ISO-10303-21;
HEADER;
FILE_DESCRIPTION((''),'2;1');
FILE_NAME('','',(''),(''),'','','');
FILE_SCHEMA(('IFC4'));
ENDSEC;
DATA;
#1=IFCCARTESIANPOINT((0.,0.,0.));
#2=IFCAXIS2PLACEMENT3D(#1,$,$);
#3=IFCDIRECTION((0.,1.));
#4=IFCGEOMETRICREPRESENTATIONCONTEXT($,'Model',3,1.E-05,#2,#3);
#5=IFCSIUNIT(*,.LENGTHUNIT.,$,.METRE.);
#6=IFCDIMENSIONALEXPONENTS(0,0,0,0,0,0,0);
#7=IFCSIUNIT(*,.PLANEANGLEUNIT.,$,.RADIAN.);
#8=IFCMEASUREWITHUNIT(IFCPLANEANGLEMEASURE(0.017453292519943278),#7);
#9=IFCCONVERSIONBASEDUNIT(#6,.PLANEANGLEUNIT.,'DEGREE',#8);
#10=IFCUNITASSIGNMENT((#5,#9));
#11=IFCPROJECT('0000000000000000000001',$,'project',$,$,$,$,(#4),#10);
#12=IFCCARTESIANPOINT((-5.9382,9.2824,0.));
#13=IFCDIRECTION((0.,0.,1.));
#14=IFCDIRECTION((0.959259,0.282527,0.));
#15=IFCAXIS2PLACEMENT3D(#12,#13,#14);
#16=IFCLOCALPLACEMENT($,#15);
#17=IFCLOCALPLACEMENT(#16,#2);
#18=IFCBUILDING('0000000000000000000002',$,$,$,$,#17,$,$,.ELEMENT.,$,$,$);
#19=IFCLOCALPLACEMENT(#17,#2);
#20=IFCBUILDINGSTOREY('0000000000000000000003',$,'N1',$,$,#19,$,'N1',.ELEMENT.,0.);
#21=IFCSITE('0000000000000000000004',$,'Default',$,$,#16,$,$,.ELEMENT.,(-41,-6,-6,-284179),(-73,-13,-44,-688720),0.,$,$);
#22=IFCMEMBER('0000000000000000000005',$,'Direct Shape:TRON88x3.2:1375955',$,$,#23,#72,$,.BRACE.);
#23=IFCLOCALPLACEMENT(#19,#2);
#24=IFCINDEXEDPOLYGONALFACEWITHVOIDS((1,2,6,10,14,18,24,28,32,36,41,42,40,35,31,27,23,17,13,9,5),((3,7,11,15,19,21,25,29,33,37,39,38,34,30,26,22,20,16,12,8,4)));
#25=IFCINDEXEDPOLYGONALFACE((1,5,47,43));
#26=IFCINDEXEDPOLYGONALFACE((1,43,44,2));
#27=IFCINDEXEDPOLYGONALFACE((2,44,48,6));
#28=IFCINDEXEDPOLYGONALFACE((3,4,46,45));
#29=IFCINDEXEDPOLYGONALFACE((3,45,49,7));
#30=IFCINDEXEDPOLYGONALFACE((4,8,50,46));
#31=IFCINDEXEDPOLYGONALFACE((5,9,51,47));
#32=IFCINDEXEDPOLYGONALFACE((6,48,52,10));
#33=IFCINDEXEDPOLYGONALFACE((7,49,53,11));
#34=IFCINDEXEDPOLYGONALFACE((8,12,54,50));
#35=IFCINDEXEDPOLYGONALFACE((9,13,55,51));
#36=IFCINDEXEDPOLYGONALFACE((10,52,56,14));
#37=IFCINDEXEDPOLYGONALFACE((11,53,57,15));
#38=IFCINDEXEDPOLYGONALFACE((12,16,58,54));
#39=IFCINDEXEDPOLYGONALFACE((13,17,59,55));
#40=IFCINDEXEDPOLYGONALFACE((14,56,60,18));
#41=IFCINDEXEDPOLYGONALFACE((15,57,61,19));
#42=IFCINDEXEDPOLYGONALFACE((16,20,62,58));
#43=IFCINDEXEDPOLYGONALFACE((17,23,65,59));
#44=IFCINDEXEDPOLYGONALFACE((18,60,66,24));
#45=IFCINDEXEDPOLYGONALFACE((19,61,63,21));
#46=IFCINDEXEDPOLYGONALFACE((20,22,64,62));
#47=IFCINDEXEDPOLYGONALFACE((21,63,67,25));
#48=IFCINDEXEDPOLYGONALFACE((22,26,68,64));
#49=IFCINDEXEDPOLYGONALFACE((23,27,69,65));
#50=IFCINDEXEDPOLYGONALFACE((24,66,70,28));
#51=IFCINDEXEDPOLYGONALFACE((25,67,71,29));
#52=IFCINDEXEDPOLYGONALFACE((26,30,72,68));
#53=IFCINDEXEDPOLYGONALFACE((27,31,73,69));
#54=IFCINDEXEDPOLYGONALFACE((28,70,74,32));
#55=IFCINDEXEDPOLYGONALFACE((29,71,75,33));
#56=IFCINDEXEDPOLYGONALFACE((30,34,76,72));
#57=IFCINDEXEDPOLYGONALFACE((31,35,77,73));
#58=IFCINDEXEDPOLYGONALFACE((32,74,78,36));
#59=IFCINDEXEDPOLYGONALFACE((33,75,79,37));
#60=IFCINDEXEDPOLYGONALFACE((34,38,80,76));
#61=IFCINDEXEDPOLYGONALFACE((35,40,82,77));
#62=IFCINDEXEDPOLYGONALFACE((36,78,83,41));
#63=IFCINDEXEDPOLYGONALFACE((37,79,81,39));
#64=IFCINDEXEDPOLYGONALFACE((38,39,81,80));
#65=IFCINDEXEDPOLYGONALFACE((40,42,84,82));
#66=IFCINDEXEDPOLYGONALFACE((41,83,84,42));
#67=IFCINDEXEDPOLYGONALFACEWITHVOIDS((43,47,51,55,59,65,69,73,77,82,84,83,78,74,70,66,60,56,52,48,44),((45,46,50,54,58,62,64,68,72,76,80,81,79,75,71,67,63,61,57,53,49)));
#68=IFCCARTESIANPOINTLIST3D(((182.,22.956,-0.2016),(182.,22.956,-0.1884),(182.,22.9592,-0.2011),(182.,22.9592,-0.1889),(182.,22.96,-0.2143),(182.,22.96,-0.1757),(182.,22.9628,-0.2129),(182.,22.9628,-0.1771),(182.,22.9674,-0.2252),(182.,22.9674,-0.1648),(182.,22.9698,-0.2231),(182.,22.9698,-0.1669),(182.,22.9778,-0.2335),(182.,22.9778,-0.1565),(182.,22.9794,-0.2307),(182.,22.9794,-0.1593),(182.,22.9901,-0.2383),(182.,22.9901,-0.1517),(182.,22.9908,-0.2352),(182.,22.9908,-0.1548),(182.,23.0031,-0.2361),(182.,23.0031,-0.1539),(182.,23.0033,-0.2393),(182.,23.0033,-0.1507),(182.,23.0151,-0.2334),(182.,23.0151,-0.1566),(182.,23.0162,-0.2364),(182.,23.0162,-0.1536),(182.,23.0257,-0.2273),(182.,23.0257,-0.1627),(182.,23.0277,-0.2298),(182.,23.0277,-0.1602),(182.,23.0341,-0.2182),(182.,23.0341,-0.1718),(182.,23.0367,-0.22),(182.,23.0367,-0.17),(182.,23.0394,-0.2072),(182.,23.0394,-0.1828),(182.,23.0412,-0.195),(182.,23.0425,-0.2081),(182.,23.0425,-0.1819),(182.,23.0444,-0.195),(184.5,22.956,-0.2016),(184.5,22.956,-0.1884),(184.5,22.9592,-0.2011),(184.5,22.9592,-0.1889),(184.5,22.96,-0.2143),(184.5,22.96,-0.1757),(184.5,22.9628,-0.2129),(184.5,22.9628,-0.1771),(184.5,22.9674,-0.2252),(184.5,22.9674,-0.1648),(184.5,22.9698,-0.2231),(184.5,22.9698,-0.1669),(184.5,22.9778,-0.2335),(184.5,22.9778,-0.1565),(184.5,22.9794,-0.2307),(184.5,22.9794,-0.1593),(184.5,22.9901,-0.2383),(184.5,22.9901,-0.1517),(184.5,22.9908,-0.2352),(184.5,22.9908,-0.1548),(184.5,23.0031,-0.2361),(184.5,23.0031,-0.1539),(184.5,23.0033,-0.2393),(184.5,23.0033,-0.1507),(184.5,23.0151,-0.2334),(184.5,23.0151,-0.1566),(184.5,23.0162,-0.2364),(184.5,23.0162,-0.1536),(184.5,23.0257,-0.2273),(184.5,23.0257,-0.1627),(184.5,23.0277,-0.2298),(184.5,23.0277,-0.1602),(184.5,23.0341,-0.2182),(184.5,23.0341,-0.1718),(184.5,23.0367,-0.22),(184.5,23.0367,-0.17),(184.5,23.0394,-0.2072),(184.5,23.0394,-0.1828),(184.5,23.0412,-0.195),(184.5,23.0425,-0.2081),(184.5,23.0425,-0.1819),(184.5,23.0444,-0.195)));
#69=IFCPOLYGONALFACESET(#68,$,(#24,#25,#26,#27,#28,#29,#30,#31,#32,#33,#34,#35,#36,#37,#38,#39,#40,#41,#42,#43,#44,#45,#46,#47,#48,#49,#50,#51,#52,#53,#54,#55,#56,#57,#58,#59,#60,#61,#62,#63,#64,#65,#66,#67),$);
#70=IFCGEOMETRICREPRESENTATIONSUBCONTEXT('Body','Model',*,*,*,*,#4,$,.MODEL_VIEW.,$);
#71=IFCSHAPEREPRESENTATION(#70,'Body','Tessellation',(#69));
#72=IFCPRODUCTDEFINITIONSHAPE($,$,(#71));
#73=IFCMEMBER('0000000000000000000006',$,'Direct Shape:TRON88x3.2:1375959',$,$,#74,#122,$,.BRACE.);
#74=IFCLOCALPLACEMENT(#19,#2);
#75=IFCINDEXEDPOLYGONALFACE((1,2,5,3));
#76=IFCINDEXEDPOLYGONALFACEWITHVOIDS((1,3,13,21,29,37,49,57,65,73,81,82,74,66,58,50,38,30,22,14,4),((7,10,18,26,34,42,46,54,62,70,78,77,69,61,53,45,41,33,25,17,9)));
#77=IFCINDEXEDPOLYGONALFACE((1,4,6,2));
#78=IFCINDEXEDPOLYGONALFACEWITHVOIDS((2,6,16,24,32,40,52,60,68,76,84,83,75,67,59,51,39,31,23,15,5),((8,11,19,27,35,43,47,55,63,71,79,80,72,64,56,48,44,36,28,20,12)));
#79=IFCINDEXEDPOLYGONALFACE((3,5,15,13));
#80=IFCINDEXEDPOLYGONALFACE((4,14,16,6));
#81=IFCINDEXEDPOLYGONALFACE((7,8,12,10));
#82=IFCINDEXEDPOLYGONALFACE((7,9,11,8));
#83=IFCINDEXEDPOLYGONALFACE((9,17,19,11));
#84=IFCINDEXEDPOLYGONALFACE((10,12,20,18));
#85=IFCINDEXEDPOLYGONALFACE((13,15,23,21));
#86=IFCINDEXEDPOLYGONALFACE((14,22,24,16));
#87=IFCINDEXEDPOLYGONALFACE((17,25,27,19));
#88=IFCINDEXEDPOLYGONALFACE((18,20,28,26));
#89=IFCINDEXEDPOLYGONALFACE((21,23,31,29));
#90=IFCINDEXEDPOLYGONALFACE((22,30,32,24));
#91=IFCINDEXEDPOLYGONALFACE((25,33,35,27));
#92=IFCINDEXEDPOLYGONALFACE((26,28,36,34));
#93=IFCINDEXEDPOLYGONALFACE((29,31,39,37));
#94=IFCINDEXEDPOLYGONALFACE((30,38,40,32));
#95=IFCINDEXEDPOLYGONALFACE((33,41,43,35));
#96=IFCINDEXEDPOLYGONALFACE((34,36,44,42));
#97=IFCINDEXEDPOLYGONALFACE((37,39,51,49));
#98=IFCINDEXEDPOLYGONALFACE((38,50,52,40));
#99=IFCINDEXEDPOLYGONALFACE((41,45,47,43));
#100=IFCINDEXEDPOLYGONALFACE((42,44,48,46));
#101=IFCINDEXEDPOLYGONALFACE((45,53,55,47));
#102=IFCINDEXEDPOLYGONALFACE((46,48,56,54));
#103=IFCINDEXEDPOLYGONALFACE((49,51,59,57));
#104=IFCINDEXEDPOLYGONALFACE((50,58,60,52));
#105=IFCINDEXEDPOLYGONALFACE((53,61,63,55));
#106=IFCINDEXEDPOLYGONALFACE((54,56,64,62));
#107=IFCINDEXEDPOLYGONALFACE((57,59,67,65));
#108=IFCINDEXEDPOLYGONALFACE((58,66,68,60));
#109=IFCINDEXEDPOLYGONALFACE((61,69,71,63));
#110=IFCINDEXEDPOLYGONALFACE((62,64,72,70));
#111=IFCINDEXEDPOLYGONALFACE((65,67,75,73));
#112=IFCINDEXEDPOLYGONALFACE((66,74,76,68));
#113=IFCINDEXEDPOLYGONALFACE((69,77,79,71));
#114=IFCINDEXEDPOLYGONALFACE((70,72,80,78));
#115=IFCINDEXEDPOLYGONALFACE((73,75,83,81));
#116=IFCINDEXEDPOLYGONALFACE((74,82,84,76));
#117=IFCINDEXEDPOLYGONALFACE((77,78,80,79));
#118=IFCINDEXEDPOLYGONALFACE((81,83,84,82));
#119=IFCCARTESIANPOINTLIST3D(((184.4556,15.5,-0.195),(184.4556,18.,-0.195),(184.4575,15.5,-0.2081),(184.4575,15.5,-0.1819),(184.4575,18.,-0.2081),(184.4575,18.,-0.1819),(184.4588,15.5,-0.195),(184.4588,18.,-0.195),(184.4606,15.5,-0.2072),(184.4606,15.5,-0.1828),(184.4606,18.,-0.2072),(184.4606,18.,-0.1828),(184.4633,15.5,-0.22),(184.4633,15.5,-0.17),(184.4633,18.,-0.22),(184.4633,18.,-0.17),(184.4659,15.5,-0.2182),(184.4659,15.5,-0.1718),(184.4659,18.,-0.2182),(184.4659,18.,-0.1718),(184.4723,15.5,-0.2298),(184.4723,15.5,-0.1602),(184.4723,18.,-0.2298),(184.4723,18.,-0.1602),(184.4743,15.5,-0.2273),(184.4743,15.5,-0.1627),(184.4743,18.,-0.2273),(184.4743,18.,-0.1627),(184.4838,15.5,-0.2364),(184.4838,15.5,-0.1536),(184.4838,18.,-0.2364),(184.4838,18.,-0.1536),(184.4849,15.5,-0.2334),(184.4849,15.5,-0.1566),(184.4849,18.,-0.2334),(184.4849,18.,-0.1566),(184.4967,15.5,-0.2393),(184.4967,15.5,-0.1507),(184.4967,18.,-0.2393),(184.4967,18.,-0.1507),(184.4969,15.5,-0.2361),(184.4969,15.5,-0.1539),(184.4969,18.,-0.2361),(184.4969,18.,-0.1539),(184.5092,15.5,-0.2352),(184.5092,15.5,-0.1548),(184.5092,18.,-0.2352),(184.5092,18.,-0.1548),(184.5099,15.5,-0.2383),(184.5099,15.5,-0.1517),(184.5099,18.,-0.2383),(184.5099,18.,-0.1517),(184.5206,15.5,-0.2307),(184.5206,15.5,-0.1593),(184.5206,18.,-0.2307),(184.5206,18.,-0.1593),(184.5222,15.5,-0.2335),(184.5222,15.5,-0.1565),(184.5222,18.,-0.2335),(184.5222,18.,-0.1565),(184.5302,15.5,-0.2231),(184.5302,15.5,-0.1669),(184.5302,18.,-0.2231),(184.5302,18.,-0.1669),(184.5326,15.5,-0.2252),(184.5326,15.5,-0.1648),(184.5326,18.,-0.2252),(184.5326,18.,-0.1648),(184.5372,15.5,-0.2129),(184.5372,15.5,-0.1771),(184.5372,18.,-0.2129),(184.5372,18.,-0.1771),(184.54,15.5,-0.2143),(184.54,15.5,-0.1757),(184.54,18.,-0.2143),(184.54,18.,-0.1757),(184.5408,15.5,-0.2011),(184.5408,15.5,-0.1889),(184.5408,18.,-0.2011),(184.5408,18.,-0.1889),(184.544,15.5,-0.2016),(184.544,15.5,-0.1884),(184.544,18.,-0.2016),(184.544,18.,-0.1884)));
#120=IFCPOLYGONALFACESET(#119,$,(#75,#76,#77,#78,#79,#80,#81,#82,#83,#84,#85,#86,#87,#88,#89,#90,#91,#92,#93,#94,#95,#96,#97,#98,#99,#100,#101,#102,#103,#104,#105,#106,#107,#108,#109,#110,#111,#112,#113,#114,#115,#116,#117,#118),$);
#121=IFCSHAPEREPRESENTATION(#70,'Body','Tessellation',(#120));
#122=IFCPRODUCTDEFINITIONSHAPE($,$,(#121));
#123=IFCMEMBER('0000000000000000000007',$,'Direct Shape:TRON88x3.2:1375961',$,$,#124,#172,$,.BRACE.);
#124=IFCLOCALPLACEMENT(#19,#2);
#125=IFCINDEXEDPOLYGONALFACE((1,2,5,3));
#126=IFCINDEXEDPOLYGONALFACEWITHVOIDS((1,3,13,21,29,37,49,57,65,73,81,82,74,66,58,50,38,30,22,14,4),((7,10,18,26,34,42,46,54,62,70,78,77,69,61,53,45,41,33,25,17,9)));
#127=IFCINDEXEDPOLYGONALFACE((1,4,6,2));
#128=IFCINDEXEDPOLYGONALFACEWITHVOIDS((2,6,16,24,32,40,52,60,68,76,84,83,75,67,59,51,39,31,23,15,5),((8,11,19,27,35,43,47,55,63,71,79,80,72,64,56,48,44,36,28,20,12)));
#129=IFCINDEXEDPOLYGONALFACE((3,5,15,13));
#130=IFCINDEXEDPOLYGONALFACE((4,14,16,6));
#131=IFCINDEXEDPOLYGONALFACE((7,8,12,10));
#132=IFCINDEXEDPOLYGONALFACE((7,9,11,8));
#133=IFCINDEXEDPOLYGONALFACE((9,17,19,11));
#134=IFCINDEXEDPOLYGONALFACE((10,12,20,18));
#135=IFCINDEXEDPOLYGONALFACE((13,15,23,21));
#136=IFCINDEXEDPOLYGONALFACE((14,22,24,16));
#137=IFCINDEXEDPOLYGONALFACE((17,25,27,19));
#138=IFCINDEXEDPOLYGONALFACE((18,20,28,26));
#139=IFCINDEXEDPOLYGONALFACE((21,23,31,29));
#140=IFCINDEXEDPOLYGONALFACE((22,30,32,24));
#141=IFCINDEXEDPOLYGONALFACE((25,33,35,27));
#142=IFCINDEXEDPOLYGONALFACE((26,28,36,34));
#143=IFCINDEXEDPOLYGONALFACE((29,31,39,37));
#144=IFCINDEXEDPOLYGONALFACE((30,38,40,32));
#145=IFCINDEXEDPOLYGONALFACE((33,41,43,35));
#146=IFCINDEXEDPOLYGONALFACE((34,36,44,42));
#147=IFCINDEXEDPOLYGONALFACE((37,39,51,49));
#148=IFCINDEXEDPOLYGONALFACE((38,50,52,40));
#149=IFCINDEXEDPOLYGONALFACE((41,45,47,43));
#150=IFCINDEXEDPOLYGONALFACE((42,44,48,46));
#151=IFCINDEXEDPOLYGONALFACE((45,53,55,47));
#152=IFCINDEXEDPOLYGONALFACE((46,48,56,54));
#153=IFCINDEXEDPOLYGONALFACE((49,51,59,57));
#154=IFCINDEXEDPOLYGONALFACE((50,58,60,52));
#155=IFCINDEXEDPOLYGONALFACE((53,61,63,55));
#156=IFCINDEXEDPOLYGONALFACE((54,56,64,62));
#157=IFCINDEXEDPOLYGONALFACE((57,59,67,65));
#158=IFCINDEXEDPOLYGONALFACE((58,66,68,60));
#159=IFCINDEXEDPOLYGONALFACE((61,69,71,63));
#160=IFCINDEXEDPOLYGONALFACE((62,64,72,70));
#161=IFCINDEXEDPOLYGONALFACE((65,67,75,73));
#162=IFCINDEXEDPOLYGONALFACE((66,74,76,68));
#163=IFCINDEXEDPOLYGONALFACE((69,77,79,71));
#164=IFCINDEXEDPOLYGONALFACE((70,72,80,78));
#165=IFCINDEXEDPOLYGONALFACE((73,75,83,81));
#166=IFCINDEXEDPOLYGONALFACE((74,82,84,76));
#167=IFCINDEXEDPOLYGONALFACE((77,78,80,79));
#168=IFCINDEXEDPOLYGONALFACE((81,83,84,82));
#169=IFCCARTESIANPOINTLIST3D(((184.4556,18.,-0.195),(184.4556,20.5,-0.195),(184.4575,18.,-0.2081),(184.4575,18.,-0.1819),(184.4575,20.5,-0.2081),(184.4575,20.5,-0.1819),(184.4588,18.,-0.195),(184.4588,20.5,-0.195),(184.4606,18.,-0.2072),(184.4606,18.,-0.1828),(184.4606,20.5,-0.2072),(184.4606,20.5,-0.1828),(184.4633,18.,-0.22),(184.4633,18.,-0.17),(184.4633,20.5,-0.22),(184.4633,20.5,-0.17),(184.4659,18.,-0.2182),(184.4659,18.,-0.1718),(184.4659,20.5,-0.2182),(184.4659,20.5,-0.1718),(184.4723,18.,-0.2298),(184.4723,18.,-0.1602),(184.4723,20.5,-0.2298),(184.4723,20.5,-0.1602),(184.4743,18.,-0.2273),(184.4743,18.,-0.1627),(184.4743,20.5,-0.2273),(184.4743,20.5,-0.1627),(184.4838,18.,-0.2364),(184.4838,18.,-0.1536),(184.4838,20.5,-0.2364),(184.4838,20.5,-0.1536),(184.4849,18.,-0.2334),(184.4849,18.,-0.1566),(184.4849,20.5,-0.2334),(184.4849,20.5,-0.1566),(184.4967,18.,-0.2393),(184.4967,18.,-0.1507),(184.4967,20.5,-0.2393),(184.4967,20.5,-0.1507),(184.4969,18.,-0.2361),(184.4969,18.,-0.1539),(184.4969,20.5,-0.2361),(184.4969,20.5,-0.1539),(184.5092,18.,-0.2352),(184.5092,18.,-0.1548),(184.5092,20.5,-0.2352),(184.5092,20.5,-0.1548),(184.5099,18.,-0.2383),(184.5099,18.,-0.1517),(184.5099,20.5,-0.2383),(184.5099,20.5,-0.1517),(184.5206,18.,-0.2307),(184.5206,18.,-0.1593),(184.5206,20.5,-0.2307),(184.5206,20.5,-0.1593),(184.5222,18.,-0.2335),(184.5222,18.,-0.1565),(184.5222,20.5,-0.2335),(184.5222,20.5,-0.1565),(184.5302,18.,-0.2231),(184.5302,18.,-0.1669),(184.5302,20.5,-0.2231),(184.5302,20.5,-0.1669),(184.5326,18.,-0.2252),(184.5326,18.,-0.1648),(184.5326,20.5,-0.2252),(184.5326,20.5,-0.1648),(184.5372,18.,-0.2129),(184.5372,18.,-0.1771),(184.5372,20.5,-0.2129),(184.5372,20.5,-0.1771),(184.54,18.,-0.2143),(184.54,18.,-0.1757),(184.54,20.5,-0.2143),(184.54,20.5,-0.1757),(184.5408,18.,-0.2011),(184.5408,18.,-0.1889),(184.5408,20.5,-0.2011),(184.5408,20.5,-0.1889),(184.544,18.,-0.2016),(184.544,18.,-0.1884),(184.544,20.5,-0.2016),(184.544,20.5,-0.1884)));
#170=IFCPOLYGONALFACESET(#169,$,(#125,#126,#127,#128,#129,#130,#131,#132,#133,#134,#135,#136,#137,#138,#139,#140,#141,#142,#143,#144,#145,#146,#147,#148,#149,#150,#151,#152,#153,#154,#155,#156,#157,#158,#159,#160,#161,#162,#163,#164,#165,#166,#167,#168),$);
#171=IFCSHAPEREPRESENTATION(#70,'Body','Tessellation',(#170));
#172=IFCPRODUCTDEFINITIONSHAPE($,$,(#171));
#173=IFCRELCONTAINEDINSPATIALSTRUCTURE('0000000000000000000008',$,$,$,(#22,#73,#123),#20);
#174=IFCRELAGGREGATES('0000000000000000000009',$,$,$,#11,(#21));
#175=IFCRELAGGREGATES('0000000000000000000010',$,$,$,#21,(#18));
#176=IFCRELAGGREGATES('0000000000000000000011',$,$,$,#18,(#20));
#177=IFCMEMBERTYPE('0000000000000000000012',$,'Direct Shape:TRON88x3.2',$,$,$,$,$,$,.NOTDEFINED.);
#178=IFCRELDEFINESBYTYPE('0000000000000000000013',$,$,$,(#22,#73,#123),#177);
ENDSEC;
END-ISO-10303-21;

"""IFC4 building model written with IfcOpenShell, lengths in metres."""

from ifc_helpers import new_model, entity, si_unit, converted_unit, direction, frame, frame_2d, origin, place, context, subcontext, project, spatial, hollow_circle, extrude, type_object, element, save


model = new_model("IFC4")

# Units and contexts
model_context = context("Model", 3, precision=1e-05, world=origin(), true_north=direction((0.0, 1.0)))
body_context = subcontext(model_context, "Body", "Model", "MODEL_VIEW")
ifc_project = project(units=[si_unit("LENGTHUNIT", "METRE"), converted_unit("PLANEANGLEUNIT", "DEGREE", entity("IfcPlaneAngleMeasure", 0.017453292519943278), si_unit("PLANEANGLEUNIT", "RADIAN"), dimensions=[0, 0, 0, 0, 0, 0, 0])], contexts=[model_context])

# Site, building, storey
site_placement = place(None, frame((-5.9382, 9.2824, 0.0), z_axis=(0.0, 0.0, 1.0), x_axis=(0.959259, 0.282527, 0.0)))
site = spatial("IfcSite", under=ifc_project, at=site_placement, Name="Default", CompositionType="ELEMENT", RefLatitude=(-41, -6, -6, -284179), RefLongitude=(-73, -13, -44, -688720), RefElevation=0.0)
building_placement = place(site_placement, origin())
building = spatial("IfcBuilding", under=site, at=building_placement, CompositionType="ELEMENT")
storey_placement = place(building_placement, origin())
storey = spatial("IfcBuildingStorey", under=building, at=storey_placement, Name="N1", LongName="N1", CompositionType="ELEMENT", Elevation=0.0)

# Members
member_type_1 = type_object("IfcMemberType", Name="Direct Shape:TRON88x3.2", PredefinedType="NOTDEFINED")
member_1_placement = place(storey_placement, origin())
element("IfcMember", 1, at=member_1_placement, inside=storey, type_object=member_type_1, Name="Direct Shape:TRON88x3.2:1375955", PredefinedType="BRACE", context=body_context, shape_type="SweptSolid", body=[
    extrude(hollow_circle(Radius=0.0445, WallThickness=0.0032, at=frame_2d((0.0, 0.0), x_axis=(1.0, 0.0))), frame((182.0, 23.0, -0.195), z_axis=(1.0, 0.0, 0.0), x_axis=(0.0, 1.0, 0.0)), (0.0, 0.0, 1.0), 2.5),
])
member_2_placement = place(storey_placement, origin())
element("IfcMember", 2, at=member_2_placement, inside=storey, type_object=member_type_1, Name="Direct Shape:TRON88x3.2:1375959", PredefinedType="BRACE", context=body_context, shape_type="SweptSolid", body=[
    extrude(hollow_circle(Radius=0.0445, WallThickness=0.0032, at=frame_2d((0.0, 0.0), x_axis=(1.0, 0.0))), frame((184.5, 15.5, -0.195), z_axis=(0.0, 1.0, 0.0), x_axis=(-1.0, 0.0, 0.0)), (0.0, 0.0, 1.0), 2.5),
])
member_3_placement = place(storey_placement, origin())
element("IfcMember", 3, at=member_3_placement, inside=storey, type_object=member_type_1, Name="Direct Shape:TRON88x3.2:1375961", PredefinedType="BRACE", context=body_context, shape_type="SweptSolid", body=[
    extrude(hollow_circle(Radius=0.0445, WallThickness=0.0032, at=frame_2d((0.0, 0.0), x_axis=(1.0, 0.0))), frame((184.5, 18.0, -0.195), z_axis=(0.0, 1.0, 0.0), x_axis=(-1.0, 0.0, 0.0)), (0.0, 0.0, 1.0), 2.5),
])

save(model, "model.ifc")
